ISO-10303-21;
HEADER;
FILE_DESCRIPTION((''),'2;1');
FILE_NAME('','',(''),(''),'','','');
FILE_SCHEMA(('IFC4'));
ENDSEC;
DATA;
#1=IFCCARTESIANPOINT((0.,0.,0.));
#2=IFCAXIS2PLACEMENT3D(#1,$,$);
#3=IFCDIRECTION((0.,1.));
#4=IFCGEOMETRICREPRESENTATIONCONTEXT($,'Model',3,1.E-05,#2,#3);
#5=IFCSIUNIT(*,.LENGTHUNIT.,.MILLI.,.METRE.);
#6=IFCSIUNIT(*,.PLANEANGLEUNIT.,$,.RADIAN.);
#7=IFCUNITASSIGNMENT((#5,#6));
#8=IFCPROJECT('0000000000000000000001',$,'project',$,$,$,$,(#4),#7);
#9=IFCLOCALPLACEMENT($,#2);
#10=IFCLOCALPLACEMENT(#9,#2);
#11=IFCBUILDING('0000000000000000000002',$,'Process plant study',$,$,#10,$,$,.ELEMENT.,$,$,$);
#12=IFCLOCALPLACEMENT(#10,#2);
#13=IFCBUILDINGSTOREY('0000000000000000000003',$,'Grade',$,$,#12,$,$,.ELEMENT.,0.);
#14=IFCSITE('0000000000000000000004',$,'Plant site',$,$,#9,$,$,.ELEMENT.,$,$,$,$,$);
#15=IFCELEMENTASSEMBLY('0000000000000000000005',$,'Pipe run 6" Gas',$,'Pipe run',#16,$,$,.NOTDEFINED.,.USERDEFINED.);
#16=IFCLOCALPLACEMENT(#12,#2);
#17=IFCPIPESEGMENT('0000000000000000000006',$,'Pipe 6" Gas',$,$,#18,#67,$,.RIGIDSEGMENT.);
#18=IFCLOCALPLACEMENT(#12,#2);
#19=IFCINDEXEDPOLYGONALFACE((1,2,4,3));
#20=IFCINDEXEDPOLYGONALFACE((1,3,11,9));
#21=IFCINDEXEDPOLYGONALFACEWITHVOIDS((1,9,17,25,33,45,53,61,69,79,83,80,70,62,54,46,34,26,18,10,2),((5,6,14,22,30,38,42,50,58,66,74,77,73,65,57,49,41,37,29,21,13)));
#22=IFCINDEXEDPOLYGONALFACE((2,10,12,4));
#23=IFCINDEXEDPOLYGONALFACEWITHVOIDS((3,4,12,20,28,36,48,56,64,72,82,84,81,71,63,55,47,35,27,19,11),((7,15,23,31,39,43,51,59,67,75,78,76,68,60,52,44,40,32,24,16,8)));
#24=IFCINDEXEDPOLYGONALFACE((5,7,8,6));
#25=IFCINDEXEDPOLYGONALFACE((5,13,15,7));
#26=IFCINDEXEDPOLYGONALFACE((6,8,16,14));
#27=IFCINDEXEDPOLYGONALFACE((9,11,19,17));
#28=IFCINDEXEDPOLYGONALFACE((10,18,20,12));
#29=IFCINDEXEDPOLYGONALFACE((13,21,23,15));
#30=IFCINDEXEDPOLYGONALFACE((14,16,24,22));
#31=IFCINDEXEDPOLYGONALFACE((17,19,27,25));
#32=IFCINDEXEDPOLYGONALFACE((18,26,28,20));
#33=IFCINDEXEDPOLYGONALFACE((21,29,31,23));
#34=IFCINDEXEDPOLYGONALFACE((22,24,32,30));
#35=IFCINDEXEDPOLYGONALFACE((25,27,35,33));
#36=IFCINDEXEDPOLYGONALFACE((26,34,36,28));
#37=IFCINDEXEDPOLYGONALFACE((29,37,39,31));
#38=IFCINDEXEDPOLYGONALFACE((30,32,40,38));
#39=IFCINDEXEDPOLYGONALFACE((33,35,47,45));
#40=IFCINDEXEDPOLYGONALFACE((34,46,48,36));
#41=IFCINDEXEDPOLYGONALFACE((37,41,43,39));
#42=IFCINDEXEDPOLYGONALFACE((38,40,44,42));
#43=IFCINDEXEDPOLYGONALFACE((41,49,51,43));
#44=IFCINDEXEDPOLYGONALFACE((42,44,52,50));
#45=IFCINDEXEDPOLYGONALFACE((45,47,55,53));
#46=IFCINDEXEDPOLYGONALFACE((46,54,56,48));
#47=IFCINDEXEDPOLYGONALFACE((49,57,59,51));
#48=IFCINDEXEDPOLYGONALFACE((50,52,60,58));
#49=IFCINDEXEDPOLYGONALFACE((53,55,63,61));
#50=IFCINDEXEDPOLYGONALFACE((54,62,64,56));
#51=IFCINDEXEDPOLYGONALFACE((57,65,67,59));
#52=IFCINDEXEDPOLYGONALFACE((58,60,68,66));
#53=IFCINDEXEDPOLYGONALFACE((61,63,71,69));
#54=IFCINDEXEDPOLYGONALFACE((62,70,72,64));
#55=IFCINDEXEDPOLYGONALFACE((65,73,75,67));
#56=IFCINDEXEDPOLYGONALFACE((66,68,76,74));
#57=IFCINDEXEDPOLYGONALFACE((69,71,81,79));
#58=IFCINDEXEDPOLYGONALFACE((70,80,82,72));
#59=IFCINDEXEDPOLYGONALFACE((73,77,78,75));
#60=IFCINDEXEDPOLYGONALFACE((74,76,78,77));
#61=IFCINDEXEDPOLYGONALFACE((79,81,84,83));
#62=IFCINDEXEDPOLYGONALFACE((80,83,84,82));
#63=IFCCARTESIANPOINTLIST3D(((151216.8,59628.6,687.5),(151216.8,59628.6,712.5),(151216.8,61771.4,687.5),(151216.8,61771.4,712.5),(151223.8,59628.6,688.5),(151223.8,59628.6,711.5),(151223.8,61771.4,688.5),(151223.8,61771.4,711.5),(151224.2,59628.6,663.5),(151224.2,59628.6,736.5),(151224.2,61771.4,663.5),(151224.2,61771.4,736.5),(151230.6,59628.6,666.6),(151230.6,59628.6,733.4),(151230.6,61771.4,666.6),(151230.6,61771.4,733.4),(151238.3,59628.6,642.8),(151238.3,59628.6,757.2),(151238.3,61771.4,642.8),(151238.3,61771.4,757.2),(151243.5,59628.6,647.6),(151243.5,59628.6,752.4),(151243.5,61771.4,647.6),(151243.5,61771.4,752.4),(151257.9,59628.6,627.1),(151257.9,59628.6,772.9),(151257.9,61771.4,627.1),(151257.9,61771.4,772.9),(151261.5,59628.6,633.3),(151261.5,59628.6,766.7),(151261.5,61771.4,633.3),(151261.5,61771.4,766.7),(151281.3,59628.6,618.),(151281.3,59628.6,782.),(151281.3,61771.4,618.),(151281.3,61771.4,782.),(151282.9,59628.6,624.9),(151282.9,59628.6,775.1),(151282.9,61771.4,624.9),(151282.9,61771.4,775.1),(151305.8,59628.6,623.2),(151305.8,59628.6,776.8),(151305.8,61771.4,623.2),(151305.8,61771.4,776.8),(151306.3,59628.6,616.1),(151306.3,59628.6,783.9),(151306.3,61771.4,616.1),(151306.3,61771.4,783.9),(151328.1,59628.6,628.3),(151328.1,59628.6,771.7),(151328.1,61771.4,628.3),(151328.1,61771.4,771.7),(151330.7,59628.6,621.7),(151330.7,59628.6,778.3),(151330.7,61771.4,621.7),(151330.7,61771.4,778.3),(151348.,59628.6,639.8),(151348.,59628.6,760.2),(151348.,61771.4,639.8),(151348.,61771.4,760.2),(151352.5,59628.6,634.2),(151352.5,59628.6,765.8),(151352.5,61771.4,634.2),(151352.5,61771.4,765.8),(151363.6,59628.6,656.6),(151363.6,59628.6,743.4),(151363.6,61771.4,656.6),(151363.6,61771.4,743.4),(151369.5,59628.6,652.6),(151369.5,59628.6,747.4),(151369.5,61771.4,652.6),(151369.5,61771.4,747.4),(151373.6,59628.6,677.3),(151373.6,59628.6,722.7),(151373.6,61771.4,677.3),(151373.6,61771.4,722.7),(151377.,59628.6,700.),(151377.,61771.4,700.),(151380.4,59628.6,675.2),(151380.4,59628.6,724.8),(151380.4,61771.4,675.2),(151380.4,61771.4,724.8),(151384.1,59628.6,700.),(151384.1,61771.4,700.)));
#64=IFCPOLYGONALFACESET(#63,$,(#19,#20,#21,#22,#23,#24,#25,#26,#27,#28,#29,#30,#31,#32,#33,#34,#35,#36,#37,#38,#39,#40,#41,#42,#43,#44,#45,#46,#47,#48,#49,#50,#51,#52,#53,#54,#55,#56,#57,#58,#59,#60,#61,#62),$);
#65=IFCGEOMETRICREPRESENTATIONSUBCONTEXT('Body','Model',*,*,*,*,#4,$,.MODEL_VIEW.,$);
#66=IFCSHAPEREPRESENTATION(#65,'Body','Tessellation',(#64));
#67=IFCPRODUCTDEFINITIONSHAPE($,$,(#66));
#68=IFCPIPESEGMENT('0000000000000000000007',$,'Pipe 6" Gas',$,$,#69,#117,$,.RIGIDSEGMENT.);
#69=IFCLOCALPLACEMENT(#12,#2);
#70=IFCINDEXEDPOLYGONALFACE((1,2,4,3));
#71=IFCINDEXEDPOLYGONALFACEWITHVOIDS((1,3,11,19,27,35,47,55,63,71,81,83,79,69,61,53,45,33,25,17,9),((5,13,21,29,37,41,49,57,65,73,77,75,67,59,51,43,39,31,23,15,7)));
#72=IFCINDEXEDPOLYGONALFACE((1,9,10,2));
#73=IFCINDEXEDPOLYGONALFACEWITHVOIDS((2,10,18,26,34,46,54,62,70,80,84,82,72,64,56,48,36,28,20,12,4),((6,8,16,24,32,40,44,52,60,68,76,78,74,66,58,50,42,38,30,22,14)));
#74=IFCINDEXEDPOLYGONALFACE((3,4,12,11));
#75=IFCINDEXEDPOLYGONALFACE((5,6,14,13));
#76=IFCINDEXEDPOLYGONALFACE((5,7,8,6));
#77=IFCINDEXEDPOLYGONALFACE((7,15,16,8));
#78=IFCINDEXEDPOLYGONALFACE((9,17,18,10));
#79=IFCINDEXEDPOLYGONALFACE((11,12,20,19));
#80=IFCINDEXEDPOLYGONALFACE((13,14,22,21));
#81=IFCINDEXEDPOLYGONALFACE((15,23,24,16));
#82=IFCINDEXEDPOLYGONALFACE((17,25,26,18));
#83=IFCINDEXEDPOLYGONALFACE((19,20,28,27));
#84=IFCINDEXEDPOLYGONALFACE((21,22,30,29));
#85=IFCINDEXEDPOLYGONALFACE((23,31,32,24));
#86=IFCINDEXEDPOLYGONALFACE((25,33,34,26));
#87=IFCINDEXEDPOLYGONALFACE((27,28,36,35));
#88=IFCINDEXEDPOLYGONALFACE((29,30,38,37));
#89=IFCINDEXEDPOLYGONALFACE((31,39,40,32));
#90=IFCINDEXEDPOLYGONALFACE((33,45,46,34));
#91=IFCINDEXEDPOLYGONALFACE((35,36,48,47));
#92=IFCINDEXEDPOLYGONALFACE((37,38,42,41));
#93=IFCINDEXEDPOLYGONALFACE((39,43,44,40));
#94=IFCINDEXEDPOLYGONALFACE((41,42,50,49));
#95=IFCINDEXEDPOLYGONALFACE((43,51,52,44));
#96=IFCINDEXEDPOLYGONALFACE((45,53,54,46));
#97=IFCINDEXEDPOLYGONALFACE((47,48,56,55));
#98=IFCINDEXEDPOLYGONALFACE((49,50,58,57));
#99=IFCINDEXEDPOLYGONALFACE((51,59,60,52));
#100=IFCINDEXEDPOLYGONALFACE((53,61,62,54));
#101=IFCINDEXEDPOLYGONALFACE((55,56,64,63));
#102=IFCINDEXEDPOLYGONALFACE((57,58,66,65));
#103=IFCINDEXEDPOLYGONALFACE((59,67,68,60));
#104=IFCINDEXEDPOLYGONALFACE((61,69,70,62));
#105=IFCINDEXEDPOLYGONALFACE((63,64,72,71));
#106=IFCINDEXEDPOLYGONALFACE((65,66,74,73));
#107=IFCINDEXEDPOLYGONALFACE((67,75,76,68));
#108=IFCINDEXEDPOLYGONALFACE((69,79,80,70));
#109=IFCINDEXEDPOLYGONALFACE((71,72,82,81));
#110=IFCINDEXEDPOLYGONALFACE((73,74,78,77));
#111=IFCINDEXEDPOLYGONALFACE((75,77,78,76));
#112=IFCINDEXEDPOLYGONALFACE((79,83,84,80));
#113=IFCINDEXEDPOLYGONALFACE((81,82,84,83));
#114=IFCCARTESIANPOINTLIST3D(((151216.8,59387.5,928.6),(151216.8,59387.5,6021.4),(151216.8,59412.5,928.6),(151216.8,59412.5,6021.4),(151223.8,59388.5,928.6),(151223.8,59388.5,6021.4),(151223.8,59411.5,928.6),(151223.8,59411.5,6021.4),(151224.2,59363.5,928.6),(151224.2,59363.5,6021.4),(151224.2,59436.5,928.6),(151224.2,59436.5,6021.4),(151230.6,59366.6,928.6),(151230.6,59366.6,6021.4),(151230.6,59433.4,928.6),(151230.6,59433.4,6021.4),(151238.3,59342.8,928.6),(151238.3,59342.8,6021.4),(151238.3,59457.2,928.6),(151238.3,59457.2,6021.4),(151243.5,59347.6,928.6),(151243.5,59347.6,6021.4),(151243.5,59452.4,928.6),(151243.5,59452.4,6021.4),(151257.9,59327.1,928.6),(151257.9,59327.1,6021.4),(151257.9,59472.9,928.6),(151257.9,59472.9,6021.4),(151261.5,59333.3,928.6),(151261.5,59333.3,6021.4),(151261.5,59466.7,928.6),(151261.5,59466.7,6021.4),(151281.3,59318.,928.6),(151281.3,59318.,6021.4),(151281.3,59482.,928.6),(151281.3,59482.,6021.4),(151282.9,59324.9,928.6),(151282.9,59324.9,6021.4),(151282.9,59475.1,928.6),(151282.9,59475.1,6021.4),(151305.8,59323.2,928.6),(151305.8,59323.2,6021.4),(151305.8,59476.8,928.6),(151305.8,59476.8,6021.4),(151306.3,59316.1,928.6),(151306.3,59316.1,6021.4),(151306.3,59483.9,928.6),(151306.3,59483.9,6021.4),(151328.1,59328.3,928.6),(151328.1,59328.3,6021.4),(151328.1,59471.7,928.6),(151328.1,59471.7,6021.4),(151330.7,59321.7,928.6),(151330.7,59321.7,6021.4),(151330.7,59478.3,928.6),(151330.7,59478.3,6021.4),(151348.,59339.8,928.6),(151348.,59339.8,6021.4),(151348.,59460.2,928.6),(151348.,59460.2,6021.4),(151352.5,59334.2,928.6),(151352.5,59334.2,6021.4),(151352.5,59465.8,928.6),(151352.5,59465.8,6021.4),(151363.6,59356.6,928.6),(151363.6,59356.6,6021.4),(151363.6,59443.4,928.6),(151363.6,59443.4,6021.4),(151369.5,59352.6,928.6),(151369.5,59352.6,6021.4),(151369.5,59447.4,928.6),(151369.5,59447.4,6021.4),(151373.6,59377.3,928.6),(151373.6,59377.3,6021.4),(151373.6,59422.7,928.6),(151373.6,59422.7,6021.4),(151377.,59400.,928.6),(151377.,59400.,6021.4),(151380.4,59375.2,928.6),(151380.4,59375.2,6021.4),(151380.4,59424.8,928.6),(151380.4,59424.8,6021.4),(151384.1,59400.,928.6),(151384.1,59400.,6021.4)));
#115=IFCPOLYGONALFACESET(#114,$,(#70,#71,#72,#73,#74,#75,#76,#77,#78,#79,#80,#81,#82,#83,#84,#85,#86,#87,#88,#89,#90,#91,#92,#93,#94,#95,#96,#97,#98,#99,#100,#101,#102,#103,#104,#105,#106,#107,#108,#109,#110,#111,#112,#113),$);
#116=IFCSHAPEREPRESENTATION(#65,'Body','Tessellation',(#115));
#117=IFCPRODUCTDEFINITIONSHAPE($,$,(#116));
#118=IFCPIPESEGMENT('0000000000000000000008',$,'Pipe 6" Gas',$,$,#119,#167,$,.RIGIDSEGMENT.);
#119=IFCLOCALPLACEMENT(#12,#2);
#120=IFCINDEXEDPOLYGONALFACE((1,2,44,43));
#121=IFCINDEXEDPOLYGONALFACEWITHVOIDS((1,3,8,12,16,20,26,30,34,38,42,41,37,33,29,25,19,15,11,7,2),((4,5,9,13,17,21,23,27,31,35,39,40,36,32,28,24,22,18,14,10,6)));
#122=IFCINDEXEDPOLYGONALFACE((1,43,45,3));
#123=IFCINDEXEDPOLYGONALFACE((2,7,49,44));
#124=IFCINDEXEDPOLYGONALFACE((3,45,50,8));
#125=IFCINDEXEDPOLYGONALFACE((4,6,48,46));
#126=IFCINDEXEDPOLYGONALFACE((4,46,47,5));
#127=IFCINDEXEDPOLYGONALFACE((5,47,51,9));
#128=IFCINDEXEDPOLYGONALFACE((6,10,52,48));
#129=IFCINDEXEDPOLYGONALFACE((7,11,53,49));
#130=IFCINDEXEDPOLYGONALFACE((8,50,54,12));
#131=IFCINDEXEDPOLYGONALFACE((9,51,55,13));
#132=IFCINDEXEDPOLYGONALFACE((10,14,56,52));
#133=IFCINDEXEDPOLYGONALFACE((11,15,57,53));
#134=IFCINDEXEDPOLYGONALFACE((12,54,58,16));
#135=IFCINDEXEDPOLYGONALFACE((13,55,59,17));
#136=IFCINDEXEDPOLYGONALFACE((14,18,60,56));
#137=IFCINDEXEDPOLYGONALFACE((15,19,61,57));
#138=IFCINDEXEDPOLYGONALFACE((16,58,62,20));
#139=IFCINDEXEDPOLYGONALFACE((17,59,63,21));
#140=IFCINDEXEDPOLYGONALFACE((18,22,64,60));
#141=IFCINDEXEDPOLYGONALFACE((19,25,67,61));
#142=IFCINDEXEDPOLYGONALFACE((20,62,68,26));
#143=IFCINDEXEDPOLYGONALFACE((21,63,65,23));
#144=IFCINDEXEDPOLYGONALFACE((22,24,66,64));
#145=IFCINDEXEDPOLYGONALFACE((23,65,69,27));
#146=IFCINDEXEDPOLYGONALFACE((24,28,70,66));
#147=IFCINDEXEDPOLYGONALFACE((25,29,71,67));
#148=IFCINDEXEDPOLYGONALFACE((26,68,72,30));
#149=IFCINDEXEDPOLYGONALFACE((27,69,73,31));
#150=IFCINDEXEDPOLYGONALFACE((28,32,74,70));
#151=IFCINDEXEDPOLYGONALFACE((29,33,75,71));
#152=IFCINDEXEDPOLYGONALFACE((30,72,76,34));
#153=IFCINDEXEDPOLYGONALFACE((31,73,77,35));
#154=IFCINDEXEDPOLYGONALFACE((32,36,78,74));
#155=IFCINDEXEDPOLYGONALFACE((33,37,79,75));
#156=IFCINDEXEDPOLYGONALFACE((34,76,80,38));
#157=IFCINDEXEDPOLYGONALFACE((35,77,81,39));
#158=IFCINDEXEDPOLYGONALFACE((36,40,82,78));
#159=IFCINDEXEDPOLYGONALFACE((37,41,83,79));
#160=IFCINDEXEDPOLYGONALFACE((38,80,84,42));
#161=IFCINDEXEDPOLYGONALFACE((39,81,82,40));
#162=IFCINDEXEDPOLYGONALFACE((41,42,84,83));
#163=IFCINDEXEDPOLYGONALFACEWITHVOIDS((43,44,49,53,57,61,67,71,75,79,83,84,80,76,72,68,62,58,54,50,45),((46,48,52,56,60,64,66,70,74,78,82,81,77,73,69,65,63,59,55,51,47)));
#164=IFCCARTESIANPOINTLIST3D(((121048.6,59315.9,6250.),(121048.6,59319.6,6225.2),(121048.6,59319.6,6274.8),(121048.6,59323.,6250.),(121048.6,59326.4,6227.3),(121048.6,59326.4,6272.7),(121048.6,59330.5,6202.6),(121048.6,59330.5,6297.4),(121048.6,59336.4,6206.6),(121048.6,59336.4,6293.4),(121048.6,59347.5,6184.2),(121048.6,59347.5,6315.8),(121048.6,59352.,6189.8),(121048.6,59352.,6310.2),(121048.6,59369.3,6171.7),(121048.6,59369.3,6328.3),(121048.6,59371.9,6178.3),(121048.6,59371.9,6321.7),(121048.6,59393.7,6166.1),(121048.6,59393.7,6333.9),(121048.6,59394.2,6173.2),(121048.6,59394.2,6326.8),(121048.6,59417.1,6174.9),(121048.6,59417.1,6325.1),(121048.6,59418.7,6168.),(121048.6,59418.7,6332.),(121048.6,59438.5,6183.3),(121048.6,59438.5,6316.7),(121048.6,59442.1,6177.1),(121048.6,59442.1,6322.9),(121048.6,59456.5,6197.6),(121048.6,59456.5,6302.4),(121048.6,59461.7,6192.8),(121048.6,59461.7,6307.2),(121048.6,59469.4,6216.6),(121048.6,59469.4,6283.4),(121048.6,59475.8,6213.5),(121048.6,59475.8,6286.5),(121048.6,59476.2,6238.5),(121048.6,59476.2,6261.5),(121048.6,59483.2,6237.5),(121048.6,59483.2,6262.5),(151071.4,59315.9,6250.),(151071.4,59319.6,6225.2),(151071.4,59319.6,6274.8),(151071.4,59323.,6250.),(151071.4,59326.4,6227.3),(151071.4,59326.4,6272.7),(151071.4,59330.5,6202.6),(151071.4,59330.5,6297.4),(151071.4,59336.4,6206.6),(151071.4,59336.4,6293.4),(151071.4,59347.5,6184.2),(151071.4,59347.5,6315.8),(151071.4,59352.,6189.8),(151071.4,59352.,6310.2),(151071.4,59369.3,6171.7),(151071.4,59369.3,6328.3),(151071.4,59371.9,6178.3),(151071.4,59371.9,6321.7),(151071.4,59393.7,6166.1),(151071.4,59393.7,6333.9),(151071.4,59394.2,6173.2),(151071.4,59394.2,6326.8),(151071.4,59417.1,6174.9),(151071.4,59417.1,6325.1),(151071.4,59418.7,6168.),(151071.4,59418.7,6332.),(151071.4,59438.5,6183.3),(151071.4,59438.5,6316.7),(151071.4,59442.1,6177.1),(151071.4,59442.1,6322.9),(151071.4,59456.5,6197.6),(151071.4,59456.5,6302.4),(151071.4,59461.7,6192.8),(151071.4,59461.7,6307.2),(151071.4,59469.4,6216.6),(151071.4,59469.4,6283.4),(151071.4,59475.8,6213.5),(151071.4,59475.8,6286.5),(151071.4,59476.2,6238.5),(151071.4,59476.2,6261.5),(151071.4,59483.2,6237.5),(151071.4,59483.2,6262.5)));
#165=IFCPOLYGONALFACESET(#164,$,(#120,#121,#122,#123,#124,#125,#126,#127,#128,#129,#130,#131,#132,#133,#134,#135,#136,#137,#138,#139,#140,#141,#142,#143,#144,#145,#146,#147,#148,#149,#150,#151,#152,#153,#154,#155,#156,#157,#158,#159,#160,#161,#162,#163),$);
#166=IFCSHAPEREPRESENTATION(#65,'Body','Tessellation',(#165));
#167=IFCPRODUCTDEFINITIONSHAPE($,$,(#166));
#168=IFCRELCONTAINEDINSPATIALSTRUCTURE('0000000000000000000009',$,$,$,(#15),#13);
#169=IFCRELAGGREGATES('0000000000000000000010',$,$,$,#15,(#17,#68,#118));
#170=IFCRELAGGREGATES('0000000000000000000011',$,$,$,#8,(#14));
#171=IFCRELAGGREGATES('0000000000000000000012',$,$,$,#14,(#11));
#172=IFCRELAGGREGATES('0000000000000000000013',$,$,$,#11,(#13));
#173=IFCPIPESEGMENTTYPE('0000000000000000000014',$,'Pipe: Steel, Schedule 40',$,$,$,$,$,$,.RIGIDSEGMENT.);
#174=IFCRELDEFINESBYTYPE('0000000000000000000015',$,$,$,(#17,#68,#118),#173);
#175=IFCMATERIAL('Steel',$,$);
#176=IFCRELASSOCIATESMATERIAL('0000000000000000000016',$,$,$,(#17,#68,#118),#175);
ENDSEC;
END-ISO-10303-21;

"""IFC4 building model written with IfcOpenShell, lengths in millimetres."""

from ifc_helpers import new_model, si_unit, direction, frame, origin, origin_with_axes, origin_2d, place, context, subcontext, project, spatial, hollow_circle, extrude, material, type_object, element, aggregate, save


model = new_model("IFC4")

# Units and contexts
model_context = context("Model", 3, precision=1e-05, world=origin(), true_north=direction((0.0, 1.0)))
body_context = subcontext(model_context, "Body", "Model", "MODEL_VIEW")
ifc_project = project(units=[si_unit("LENGTHUNIT", "METRE", prefix="MILLI"), si_unit("PLANEANGLEUNIT", "RADIAN")], contexts=[model_context])

# Site, building, storey
site_placement = place(None, origin())
site = spatial("IfcSite", under=ifc_project, at=site_placement, Name="Plant site", CompositionType="ELEMENT")
building_placement = place(site_placement, origin())
building = spatial("IfcBuilding", under=site, at=building_placement, Name="Process plant study", CompositionType="ELEMENT")
storey_placement = place(building_placement, origin())
storey = spatial("IfcBuildingStorey", under=building, at=storey_placement, Name="Grade", CompositionType="ELEMENT", Elevation=0.0)

# Element assembly, pipe segments
ifc_material = material(Name="Steel")
pipe_segment_type = type_object("IfcPipeSegmentType", Name="Pipe: Steel, Schedule 40", PredefinedType="RIGIDSEGMENT")
assembly_1_placement = place(storey_placement, origin_with_axes())
assembly_1 = element("IfcElementAssembly", 1, at=assembly_1_placement, inside=storey, Name="Pipe run 6\" Gas", ObjectType="Pipe run", AssemblyPlace="NOTDEFINED", PredefinedType="USERDEFINED")
pipe_segment_1_placement = place(storey_placement, origin_with_axes())
pipe_segment_1 = element("IfcPipeSegment", 2, at=pipe_segment_1_placement, type_object=pipe_segment_type, material=ifc_material, Name="Pipe 6\" Gas", PredefinedType="RIGIDSEGMENT", context=body_context, shape_type="SweptSolid", body=[
    extrude(hollow_circle(Radius=84.1, WallThickness=7.1, at=origin_2d()), frame((151300.0, 61771.4, 700.0), z_axis=(0.0, -1.0, 0.0), x_axis=(1.0, 0.0, 0.0)), (0.0, 0.0, 1.0), 2142.8),
])
pipe_segment_2_placement = place(storey_placement, origin_with_axes())
pipe_segment_2 = element("IfcPipeSegment", 3, at=pipe_segment_2_placement, type_object=pipe_segment_type, material=ifc_material, Name="Pipe 6\" Gas", PredefinedType="RIGIDSEGMENT", context=body_context, shape_type="SweptSolid", body=[
    extrude(hollow_circle(Radius=84.1, WallThickness=7.1, at=origin_2d()), frame((151300.0, 59400.0, 928.6), z_axis=(0.0, 0.0, 1.0), x_axis=(1.0, 0.0, 0.0)), (0.0, 0.0, 1.0), 5092.8),
])
pipe_segment_3_placement = place(storey_placement, origin_with_axes())
pipe_segment_3 = element("IfcPipeSegment", 4, at=pipe_segment_3_placement, type_object=pipe_segment_type, material=ifc_material, Name="Pipe 6\" Gas", PredefinedType="RIGIDSEGMENT", context=body_context, shape_type="SweptSolid", body=[
    extrude(hollow_circle(Radius=84.1, WallThickness=7.1, at=origin_2d()), frame((151071.4, 59400.0, 6250.0), z_axis=(-1.0, 0.0, 0.0), x_axis=(0.0, -1.0, 0.0)), (0.0, 0.0, 1.0), 30022.8),
])

aggregate(assembly_1, [pipe_segment_1, pipe_segment_2, pipe_segment_3])

save(model, "model.ifc")
